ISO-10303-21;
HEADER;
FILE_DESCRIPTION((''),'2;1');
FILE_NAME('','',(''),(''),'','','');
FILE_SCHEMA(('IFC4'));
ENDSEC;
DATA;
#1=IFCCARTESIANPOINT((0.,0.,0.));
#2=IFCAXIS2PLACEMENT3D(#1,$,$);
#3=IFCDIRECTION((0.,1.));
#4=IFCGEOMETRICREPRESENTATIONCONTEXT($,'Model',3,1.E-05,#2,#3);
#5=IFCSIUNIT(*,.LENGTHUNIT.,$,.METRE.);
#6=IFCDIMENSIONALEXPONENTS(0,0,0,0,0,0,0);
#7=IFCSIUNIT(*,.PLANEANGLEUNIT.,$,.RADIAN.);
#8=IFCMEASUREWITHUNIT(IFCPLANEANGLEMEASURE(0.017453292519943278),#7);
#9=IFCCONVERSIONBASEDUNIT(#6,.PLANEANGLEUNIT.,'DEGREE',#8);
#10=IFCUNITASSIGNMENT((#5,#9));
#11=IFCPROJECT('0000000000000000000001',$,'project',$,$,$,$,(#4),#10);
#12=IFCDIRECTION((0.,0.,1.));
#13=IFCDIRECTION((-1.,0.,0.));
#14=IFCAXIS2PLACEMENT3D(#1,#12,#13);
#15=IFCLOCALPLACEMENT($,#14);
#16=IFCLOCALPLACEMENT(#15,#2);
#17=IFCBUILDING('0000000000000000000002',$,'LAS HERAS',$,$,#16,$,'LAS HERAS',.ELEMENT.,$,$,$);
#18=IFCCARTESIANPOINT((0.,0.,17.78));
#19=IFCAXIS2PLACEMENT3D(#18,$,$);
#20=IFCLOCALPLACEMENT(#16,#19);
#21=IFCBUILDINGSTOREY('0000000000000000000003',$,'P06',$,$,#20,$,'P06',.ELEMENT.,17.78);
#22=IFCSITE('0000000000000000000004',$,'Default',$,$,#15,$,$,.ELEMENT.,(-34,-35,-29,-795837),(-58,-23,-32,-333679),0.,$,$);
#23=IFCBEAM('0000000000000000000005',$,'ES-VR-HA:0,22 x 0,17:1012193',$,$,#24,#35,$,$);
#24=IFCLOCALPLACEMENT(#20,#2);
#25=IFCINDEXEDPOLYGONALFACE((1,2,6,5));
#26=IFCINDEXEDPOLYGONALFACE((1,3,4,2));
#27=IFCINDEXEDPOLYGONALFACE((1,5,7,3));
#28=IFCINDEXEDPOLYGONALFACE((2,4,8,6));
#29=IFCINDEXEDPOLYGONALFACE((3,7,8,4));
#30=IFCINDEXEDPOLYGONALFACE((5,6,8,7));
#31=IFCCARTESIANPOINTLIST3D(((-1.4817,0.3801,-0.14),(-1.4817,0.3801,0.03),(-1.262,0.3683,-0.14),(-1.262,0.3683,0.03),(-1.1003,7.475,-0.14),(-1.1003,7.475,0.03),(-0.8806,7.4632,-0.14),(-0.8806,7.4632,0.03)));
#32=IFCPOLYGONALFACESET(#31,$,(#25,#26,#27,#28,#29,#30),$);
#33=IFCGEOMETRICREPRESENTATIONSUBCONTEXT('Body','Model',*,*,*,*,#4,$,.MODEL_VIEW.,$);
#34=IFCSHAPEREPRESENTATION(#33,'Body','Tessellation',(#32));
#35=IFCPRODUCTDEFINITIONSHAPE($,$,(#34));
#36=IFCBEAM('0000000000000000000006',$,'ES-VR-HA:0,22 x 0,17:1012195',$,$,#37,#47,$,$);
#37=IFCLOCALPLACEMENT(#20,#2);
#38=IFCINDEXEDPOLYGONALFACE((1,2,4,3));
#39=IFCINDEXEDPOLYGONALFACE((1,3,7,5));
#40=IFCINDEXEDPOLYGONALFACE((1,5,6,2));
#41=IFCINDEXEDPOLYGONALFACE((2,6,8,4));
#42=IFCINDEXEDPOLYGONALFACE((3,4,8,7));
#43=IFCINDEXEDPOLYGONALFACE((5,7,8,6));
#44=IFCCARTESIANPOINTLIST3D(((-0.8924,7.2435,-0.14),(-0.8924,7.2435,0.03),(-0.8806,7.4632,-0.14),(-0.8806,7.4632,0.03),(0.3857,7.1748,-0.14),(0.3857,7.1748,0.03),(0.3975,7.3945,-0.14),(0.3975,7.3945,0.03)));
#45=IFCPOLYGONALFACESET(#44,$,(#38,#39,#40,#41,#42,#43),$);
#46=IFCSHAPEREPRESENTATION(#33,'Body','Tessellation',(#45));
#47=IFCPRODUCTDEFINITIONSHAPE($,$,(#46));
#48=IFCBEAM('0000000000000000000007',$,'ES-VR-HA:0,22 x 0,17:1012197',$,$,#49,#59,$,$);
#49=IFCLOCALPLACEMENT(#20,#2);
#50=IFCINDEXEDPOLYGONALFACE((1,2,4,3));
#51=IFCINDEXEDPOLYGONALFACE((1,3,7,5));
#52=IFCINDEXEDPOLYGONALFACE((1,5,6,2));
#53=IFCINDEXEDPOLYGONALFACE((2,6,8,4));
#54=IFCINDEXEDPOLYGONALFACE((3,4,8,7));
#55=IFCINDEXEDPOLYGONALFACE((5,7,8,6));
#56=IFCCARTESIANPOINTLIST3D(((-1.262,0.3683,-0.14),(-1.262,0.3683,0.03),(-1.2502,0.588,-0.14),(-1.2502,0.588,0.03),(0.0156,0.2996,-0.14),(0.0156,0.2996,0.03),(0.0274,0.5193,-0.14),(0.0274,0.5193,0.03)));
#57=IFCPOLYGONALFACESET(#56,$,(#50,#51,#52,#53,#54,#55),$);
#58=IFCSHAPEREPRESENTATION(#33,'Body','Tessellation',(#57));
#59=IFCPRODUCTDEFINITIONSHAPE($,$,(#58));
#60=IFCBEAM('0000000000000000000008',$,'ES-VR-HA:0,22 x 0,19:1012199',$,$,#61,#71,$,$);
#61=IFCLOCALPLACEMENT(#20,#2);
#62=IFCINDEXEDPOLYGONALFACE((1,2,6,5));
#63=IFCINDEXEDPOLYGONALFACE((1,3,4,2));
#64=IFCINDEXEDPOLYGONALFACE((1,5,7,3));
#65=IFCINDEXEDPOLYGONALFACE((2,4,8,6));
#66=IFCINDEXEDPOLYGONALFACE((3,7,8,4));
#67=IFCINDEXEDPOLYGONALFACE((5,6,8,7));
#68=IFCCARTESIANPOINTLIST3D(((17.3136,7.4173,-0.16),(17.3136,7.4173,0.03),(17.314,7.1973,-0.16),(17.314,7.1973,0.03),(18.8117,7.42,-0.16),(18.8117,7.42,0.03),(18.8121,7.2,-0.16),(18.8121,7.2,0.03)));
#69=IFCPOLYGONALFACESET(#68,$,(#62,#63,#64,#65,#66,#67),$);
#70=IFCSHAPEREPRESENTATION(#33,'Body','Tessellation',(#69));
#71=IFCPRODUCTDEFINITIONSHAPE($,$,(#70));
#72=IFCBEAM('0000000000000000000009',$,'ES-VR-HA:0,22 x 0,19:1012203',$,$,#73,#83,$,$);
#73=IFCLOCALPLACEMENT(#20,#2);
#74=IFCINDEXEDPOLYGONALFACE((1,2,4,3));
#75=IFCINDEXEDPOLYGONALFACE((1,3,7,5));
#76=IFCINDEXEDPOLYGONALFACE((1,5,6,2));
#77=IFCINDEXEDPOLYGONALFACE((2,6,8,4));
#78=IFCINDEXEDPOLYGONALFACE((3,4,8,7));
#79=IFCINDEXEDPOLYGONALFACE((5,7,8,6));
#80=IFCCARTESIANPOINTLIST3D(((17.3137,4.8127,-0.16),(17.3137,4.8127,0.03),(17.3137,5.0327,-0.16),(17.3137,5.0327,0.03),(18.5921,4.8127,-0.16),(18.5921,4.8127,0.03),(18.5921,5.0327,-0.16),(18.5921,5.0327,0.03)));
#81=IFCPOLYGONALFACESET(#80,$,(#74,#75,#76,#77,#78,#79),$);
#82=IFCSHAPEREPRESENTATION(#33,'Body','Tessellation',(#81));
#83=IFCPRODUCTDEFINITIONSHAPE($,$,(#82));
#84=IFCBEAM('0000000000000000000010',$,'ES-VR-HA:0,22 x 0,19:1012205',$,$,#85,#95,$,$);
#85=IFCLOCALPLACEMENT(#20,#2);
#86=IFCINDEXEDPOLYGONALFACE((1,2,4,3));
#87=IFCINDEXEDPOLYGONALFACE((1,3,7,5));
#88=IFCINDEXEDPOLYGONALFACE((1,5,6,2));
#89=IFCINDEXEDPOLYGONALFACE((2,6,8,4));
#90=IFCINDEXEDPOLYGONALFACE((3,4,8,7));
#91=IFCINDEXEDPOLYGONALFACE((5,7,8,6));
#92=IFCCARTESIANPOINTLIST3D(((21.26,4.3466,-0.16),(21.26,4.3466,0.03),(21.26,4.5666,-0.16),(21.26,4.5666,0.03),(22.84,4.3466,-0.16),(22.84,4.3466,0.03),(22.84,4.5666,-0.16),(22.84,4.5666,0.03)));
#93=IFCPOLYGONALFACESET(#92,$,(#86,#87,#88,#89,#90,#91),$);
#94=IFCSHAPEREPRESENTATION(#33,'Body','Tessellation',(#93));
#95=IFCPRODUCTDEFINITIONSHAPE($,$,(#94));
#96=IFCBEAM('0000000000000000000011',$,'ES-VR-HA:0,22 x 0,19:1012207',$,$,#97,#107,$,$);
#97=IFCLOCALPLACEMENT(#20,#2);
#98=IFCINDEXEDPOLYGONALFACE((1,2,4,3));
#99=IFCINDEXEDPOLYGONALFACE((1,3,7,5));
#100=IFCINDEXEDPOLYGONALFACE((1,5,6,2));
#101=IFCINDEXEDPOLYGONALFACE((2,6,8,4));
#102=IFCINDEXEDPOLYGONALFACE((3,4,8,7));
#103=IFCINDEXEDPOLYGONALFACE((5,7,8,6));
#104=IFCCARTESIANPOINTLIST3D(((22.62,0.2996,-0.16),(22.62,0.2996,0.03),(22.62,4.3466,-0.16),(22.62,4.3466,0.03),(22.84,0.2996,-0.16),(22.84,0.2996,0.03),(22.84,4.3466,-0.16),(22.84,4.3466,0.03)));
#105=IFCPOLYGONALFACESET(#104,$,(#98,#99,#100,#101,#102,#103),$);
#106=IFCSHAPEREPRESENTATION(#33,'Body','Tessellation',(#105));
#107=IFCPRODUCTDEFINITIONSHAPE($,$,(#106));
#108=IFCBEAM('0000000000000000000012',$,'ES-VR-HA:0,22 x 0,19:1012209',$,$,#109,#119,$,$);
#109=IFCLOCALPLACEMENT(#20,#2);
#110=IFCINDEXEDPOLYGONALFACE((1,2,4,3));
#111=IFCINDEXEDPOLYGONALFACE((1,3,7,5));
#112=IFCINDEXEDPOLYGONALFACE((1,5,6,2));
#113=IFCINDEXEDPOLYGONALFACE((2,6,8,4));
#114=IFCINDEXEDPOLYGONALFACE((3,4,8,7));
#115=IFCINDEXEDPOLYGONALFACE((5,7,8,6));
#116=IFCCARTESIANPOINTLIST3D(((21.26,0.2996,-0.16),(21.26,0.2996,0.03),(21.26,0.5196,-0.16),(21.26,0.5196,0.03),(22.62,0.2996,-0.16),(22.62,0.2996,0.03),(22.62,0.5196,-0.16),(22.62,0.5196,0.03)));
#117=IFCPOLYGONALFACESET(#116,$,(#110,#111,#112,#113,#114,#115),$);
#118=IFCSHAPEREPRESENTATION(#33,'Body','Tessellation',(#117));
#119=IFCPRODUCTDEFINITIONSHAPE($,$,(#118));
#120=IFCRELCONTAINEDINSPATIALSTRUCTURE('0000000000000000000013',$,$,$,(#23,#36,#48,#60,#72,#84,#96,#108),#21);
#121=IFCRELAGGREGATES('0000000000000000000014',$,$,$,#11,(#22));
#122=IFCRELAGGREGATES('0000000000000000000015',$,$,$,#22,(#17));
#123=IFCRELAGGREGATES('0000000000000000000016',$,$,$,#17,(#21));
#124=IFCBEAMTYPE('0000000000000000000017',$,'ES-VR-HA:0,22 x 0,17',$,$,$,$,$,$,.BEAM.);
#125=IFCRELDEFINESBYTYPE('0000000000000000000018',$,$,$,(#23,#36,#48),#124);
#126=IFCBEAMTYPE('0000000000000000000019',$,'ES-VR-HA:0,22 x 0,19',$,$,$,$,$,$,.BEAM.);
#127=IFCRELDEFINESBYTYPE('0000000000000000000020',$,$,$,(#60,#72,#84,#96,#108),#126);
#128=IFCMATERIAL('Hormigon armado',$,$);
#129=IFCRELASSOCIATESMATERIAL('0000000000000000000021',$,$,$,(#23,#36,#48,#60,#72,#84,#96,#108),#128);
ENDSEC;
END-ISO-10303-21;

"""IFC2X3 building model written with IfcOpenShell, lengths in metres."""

from ifc_helpers import new_model, entity, si_unit, converted_unit, direction, frame, frame_2d, origin, place, context, subcontext, project, spatial, rectangle, extrude, material, type_object, element, save


model = new_model("IFC2X3")

# Units and contexts
model_context = context("Model", 3, precision=1e-05, world=origin(), true_north=direction((0.0, 1.0)))
body_context = subcontext(model_context, "Body", "Model", "MODEL_VIEW")
ifc_project = project(units=[si_unit("LENGTHUNIT", "METRE"), converted_unit("PLANEANGLEUNIT", "DEGREE", entity("IfcPlaneAngleMeasure", 0.017453292519943278), si_unit("PLANEANGLEUNIT", "RADIAN"), dimensions=[0, 0, 0, 0, 0, 0, 0])], contexts=[model_context])

# Site, building, storey
site_placement = place(None, frame((0.0, 0.0, 0.0), z_axis=(0.0, 0.0, 1.0), x_axis=(-1.0, 0.0, 0.0)))
site = spatial("IfcSite", under=ifc_project, at=site_placement, Name="Default", CompositionType="ELEMENT", RefLatitude=(-34, -35, -29, -795837), RefLongitude=(-58, -23, -32, -333679), RefElevation=0.0)
building_placement = place(site_placement, origin())
building = spatial("IfcBuilding", under=site, at=building_placement, Name="LAS HERAS", LongName="LAS HERAS", CompositionType="ELEMENT")
storey_placement = place(building_placement, frame((0.0, 0.0, 17.78)))
storey = spatial("IfcBuildingStorey", under=building, at=storey_placement, Name="P06", LongName="P06", CompositionType="ELEMENT", Elevation=17.78)

# Beams
ifc_material = material(Name="Hormigon armado")
beam_type_1 = type_object("IfcBeamType", Name="ES-VR-HA:0,22 x 0,17", PredefinedType="BEAM")
beam_1_placement = place(storey_placement, frame((-0.9963, 7.3593, 0.03), z_axis=(0.0, 0.0, 1.0), x_axis=(-0.05369, -0.998558, 0.0)))
element("IfcBeam", 1, at=beam_1_placement, inside=storey, type_object=beam_type_1, material=ifc_material, Name="ES-VR-HA:0,22 x 0,17:1012193", context=body_context, shape_type="SweptSolid", body=[
    extrude(rectangle(XDim=0.17, YDim=0.22, at=frame_2d((0.0, 0.0), x_axis=(1.0, 0.0))), frame((-0.11, 0.0, -0.085), z_axis=(1.0, 0.0, 0.0), x_axis=(0.0, 0.0, -1.0)), (0.0, 0.0, 1.0), 7.1052),
])
beam_2_placement = place(storey_placement, frame((0.3916, 7.2846, 0.03), z_axis=(0.0, 0.0, 1.0), x_axis=(-0.998558, 0.05368, 0.0)))
element("IfcBeam", 2, at=beam_2_placement, inside=storey, type_object=beam_type_1, material=ifc_material, Name="ES-VR-HA:0,22 x 0,17:1012195", context=body_context, shape_type="SweptSolid", body=[
    extrude(rectangle(XDim=0.17, YDim=0.22, at=frame_2d((0.0, 0.0), x_axis=(1.0, 0.0))), frame((0.0, 0.0, -0.085), z_axis=(1.0, 0.0, 0.0), x_axis=(0.0, 0.0, -1.0)), (0.0, 0.0, 1.0), 1.28),
])
beam_3_placement = place(storey_placement, frame((0.0215, 0.4094, 0.03), z_axis=(0.0, 0.0, 1.0), x_axis=(-0.998558, 0.05369, 0.0)))
element("IfcBeam", 3, at=beam_3_placement, inside=storey, type_object=beam_type_1, material=ifc_material, Name="ES-VR-HA:0,22 x 0,17:1012197", context=body_context, shape_type="SweptSolid", body=[
    extrude(rectangle(XDim=0.17, YDim=0.22, at=frame_2d((0.0, 0.0), x_axis=(1.0, 0.0))), frame((0.0, 0.0, -0.085), z_axis=(1.0, 0.0, 0.0), x_axis=(0.0, 0.0, -1.0)), (0.0, 0.0, 1.0), 1.2795),
])
beam_type_2 = type_object("IfcBeamType", Name="ES-VR-HA:0,22 x 0,19", PredefinedType="BEAM")
beam_4_placement = place(storey_placement, frame((17.3138, 7.3073, 0.03), z_axis=(0.0, 0.0, 1.0), x_axis=(0.999998, 0.001781, 0.0)))
element("IfcBeam", 4, at=beam_4_placement, inside=storey, type_object=beam_type_2, material=ifc_material, Name="ES-VR-HA:0,22 x 0,19:1012199", context=body_context, shape_type="SweptSolid", body=[
    extrude(rectangle(XDim=0.19, YDim=0.22, at=frame_2d((0.0, 0.0), x_axis=(1.0, 0.0))), frame((0.0, 0.0, -0.095), z_axis=(1.0, 0.0, 0.0), x_axis=(0.0, 0.0, -1.0)), (0.0, 0.0, 1.0), 1.4981),
])
beam_5_placement = place(storey_placement, frame((17.3137, 4.9227, 0.03)))
element("IfcBeam", 5, at=beam_5_placement, inside=storey, type_object=beam_type_2, material=ifc_material, Name="ES-VR-HA:0,22 x 0,19:1012203", context=body_context, shape_type="SweptSolid", body=[
    extrude(rectangle(XDim=0.19, YDim=0.22, at=frame_2d((0.0, 0.0), x_axis=(1.0, 0.0))), frame((0.0, 0.0, -0.095), z_axis=(1.0, 0.0, 0.0), x_axis=(0.0, 0.0, -1.0)), (0.0, 0.0, 1.0), 1.2784),
])
beam_6_placement = place(storey_placement, frame((21.26, 4.4566, 0.03)))
element("IfcBeam", 6, at=beam_6_placement, inside=storey, type_object=beam_type_2, material=ifc_material, Name="ES-VR-HA:0,22 x 0,19:1012205", context=body_context, shape_type="SweptSolid", body=[
    extrude(rectangle(XDim=0.19, YDim=0.22, at=frame_2d((0.0, 0.0), x_axis=(1.0, 0.0))), frame((0.0, 0.0, -0.095), z_axis=(1.0, 0.0, 0.0), x_axis=(0.0, 0.0, -1.0)), (0.0, 0.0, 1.0), 1.58),
])
beam_7_placement = place(storey_placement, frame((22.73, 4.4566, 0.03), z_axis=(0.0, 0.0, 1.0), x_axis=(0.0, -1.0, 0.0)))
element("IfcBeam", 7, at=beam_7_placement, inside=storey, type_object=beam_type_2, material=ifc_material, Name="ES-VR-HA:0,22 x 0,19:1012207", context=body_context, shape_type="SweptSolid", body=[
    extrude(rectangle(XDim=0.19, YDim=0.22, at=frame_2d((0.0, 0.0), x_axis=(1.0, 0.0))), frame((0.11, 0.0, -0.095), z_axis=(1.0, 0.0, 0.0), x_axis=(0.0, 0.0, -1.0)), (0.0, 0.0, 1.0), 4.0471),
])
beam_8_placement = place(storey_placement, frame((21.26, 0.4096, 0.03)))
element("IfcBeam", 8, at=beam_8_placement, inside=storey, type_object=beam_type_2, material=ifc_material, Name="ES-VR-HA:0,22 x 0,19:1012209", context=body_context, shape_type="SweptSolid", body=[
    extrude(rectangle(XDim=0.19, YDim=0.22, at=frame_2d((0.0, 0.0), x_axis=(1.0, 0.0))), frame((0.0, 0.0, -0.095), z_axis=(1.0, 0.0, 0.0), x_axis=(0.0, 0.0, -1.0)), (0.0, 0.0, 1.0), 1.36),
])

save(model, "model.ifc")
